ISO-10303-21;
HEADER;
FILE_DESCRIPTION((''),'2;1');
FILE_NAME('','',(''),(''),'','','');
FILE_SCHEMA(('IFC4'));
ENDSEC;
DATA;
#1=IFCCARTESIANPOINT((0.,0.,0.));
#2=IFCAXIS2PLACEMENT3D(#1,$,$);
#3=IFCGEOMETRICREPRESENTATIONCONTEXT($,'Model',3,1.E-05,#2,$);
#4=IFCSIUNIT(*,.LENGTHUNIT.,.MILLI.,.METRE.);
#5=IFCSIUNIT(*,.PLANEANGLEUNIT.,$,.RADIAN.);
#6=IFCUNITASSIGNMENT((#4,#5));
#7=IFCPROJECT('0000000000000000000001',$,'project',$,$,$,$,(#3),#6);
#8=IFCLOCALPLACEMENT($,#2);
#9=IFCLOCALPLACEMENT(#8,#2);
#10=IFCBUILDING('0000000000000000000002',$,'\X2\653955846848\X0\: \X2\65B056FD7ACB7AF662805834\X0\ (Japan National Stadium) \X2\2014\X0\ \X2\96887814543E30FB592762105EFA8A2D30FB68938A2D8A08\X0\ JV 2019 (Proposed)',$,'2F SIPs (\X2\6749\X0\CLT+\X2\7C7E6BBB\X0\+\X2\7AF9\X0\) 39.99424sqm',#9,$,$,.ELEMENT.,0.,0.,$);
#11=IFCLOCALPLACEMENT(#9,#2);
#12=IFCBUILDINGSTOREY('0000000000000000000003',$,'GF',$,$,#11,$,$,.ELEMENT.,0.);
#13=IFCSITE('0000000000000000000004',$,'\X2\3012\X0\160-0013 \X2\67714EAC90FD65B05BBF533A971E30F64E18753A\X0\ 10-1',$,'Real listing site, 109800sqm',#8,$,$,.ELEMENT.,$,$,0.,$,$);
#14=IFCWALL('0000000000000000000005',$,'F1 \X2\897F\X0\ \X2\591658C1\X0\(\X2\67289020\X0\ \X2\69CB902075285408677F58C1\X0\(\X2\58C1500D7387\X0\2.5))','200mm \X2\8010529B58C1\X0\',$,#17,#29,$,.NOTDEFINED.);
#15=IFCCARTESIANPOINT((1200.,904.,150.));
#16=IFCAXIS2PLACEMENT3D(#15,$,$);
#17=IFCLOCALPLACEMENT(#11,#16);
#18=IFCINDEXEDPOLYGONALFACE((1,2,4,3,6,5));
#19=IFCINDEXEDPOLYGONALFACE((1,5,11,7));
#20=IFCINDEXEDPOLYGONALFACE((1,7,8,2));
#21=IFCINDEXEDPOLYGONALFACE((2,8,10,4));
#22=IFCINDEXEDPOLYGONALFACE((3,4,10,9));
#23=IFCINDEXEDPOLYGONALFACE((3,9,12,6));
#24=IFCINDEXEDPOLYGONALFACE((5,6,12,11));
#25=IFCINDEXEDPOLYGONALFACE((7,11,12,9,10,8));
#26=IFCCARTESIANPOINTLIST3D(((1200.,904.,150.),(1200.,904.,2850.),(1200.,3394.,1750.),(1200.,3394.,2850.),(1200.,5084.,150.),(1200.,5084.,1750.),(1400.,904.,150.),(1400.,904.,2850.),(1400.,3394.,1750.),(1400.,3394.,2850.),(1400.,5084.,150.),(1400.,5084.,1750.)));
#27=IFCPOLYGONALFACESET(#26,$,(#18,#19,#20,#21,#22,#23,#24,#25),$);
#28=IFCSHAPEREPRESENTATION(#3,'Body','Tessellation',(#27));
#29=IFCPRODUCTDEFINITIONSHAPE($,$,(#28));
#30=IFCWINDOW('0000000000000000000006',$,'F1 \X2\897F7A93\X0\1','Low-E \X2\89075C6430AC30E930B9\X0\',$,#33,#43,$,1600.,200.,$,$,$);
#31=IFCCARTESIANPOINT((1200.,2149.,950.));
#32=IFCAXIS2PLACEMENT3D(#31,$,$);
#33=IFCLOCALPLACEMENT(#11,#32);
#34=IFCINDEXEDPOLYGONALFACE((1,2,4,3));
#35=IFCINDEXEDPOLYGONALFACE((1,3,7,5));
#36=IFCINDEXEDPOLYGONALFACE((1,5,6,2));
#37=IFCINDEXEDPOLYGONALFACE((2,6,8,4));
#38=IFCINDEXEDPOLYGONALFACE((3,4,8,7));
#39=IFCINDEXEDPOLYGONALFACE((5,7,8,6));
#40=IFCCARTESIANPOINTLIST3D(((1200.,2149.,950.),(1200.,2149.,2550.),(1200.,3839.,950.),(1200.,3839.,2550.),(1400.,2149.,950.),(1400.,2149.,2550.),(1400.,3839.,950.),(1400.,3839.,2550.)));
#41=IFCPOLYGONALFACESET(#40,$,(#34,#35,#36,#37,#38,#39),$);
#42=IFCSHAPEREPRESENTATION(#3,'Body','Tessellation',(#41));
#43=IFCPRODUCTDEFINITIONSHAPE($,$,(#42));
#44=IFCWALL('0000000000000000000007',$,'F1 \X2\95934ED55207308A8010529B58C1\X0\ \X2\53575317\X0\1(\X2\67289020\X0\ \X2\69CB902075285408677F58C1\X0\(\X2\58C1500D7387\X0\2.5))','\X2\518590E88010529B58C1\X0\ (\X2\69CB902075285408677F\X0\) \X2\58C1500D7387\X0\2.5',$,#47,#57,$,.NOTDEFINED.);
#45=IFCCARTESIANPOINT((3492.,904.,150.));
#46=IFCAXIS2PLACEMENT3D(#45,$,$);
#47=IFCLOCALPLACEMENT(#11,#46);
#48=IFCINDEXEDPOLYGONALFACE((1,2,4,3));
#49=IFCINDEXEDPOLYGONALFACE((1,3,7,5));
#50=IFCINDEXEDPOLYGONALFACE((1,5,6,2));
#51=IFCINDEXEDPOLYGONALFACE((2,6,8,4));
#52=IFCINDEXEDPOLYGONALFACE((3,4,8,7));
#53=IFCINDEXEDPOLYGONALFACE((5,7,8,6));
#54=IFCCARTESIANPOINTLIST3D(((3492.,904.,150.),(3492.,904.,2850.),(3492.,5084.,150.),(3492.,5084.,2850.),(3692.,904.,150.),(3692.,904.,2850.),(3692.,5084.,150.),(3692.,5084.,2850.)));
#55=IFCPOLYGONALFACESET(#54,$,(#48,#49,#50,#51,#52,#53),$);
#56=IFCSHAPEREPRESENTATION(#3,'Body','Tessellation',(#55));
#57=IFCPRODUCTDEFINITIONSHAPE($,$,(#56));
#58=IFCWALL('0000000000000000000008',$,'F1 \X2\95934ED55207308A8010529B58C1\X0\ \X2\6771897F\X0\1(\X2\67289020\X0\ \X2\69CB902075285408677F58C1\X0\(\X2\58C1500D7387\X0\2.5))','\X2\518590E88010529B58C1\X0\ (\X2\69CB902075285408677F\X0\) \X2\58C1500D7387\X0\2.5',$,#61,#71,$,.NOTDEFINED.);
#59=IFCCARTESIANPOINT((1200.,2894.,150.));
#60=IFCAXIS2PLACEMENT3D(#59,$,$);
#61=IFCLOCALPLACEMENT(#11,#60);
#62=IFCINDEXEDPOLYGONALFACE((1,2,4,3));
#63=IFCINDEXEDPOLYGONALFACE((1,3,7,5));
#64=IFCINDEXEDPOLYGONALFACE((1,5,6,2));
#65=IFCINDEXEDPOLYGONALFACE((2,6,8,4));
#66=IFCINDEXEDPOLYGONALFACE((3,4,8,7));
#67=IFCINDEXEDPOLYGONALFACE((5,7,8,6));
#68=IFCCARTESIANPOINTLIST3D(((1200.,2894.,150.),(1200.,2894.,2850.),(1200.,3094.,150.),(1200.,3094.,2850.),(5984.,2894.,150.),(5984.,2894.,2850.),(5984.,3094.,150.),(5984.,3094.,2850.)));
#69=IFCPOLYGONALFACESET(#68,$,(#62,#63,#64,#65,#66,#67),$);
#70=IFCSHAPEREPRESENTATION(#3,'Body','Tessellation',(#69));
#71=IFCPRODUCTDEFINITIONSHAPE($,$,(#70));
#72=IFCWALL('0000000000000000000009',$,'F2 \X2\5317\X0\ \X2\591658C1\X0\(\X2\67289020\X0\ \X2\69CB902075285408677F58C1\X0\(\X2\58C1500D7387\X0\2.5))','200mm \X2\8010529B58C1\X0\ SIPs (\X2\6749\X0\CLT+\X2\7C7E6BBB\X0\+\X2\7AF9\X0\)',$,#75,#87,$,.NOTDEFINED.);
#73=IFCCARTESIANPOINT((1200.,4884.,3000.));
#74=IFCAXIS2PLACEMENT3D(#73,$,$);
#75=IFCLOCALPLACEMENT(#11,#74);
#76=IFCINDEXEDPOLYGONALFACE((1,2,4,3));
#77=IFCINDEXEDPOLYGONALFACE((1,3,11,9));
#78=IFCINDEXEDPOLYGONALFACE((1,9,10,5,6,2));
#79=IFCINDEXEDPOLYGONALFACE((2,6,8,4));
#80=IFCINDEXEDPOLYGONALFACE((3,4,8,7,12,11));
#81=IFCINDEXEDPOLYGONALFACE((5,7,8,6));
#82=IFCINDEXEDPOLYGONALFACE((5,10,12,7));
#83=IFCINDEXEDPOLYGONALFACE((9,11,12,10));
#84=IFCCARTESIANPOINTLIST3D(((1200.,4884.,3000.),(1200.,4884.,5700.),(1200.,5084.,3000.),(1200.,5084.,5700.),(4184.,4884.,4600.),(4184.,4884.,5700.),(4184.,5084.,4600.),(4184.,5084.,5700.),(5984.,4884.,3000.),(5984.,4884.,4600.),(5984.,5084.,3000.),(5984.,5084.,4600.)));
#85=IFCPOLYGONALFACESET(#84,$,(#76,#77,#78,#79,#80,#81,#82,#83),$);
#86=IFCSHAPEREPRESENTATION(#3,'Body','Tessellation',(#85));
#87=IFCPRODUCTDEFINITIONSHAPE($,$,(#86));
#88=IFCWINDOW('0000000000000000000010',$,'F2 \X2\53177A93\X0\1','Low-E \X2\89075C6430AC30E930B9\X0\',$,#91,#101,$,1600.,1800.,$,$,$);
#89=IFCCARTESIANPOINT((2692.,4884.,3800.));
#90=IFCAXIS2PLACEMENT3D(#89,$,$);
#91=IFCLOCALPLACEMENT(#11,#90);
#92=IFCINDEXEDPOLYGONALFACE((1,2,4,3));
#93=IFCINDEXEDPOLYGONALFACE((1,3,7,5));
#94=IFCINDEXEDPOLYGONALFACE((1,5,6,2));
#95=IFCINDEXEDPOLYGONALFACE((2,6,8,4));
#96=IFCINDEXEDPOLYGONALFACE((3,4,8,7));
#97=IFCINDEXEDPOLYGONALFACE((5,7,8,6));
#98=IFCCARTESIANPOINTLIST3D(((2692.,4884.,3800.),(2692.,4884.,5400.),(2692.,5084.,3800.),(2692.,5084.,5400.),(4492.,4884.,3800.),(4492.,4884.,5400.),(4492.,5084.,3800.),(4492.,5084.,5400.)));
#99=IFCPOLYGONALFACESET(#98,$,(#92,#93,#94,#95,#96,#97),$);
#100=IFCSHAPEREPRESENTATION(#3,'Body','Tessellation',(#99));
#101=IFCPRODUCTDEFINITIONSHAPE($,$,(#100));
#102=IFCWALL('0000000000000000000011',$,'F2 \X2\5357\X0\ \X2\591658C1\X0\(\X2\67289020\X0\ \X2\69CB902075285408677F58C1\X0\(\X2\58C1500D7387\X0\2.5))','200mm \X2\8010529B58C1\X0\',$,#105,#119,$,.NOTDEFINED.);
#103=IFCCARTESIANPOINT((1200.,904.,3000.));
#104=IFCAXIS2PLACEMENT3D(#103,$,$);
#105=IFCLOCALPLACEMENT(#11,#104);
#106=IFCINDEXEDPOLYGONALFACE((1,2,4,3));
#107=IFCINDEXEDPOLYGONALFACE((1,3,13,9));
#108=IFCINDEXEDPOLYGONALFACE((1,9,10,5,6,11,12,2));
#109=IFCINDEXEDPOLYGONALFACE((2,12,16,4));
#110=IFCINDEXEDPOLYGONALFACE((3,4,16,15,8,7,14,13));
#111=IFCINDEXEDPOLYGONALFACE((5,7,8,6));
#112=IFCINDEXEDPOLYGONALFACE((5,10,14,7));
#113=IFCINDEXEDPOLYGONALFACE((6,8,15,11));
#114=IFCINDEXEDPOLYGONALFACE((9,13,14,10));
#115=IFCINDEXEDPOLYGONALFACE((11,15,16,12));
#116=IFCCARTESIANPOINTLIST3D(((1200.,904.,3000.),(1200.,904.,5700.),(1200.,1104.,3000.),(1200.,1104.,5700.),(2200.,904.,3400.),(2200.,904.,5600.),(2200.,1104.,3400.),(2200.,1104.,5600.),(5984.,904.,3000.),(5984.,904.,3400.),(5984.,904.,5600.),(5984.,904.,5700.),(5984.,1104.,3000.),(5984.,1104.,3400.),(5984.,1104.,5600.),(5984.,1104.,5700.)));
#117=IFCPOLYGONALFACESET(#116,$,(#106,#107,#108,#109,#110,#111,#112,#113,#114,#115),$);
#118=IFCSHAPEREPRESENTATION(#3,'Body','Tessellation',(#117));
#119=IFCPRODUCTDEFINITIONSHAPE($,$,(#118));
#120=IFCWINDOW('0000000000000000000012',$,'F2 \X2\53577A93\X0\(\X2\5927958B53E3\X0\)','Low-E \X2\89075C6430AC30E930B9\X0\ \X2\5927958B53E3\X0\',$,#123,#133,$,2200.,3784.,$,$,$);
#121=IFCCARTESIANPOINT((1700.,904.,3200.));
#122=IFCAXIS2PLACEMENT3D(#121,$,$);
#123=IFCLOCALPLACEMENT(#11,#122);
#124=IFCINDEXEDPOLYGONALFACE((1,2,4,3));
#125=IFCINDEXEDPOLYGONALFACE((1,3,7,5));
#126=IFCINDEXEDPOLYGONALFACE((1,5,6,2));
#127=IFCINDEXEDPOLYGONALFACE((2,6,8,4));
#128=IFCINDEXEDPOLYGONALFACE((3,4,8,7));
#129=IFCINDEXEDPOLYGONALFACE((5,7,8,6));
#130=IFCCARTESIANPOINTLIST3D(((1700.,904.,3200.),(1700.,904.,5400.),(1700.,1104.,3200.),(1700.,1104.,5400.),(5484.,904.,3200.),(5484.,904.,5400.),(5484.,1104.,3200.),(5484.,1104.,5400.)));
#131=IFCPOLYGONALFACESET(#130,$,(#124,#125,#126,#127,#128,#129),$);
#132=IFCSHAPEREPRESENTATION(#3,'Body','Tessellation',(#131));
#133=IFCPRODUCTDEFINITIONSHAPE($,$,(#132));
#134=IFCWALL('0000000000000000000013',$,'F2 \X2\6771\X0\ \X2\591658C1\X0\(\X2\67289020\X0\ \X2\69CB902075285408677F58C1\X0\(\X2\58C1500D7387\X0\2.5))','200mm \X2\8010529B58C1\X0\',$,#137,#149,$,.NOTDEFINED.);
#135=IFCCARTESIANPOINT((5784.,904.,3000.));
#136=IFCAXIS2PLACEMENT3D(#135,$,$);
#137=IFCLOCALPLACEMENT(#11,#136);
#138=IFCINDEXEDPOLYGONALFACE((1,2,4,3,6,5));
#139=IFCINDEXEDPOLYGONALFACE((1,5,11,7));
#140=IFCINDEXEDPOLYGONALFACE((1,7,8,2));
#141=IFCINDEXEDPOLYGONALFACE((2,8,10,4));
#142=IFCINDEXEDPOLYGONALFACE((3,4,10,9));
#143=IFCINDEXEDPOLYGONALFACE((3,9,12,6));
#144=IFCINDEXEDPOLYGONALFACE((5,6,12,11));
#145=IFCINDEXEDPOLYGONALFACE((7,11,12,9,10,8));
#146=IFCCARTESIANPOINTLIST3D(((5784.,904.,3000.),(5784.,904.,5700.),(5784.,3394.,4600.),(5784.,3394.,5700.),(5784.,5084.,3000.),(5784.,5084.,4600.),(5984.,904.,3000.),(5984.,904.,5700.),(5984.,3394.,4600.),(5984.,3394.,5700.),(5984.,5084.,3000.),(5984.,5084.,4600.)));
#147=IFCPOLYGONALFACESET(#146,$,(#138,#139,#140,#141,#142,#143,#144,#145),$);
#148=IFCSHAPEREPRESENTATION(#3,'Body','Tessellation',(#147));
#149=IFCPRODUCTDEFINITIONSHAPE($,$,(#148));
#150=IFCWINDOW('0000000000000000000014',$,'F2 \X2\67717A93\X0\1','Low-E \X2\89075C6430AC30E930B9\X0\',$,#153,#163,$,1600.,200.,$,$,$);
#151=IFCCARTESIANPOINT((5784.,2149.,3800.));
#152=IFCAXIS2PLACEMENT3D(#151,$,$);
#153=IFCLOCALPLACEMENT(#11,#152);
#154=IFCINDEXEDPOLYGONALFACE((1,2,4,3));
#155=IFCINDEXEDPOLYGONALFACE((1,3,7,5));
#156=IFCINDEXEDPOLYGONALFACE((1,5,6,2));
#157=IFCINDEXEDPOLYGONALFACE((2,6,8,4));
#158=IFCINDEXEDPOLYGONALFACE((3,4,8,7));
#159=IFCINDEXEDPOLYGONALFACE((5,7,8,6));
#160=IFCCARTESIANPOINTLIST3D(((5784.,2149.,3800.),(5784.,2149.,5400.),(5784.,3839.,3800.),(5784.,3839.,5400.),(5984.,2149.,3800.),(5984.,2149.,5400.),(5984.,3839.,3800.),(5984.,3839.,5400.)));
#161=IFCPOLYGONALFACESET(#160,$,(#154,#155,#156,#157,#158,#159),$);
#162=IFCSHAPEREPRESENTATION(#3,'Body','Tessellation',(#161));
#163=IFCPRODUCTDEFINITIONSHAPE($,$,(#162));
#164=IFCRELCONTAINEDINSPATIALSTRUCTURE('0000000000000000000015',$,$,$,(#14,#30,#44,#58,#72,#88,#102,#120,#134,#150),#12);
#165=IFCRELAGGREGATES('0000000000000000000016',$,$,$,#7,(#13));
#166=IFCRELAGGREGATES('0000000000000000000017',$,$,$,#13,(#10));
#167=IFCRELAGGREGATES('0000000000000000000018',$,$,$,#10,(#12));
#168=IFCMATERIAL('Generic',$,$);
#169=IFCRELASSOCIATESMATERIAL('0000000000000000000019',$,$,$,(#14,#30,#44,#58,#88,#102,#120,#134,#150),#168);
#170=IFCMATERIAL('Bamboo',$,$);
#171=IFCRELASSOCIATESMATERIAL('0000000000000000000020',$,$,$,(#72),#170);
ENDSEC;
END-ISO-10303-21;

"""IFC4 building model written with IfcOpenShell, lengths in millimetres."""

from ifc_helpers import new_model, si_unit, frame, frame_2d, origin, place, context, project, spatial, rectangle, extrude, material, element, fill, save


model = new_model("IFC4")

# Units and contexts
model_context = context("Model", 3, precision=1e-05, world=origin())
ifc_project = project(units=[si_unit("LENGTHUNIT", "METRE", prefix="MILLI"), si_unit("PLANEANGLEUNIT", "RADIAN")], contexts=[model_context])

# Site, building, storey
site_placement = place(None, origin())
site = spatial("IfcSite", under=ifc_project, at=site_placement, Name="〒160-0013 東京都新宿区霞ヶ丘町 10-1", ObjectType="Real listing site, 109800sqm", CompositionType="ELEMENT", RefElevation=0.0)
building_placement = place(site_placement, origin())
building = spatial("IfcBuilding", under=site, at=building_placement, Name="改善案: 新国立競技場 (Japan National Stadium) — 隈研吾・大成建設・梓設計 JV 2019 (Proposed)", ObjectType="2F SIPs (杉CLT+籾殻+竹) 39.99424sqm", CompositionType="ELEMENT", ElevationOfRefHeight=0.0, ElevationOfTerrain=0.0)
storey_placement = place(building_placement, origin())
storey = spatial("IfcBuildingStorey", under=building, at=storey_placement, Name="GF", CompositionType="ELEMENT", Elevation=0.0)

# Shared definitions
ifc_material_1 = material(Name="Generic")

# Shared definitions
ifc_material_2 = material(Name="Bamboo")

# Wall, opening, window
wall_1_placement = place(storey_placement, frame((1200.0, 904.0, 150.0)))
wall_1 = element("IfcWall", 1, at=wall_1_placement, inside=storey, material=ifc_material_1, Name="F1 西 外壁(木造 構造用合板壁(壁倍率2.5))", Description="200mm 耐力壁", PredefinedType="NOTDEFINED", context=model_context, shape_type="SweptSolid", body=[
    extrude(rectangle(XDim=200.0, YDim=4180.0, at=frame_2d((100.0, 2090.0))), frame((1200.0, 904.0, 150.0)), (0.0, 0.0, 1.0), 2700.0),
])
opening_1_placement = place(storey_placement, frame((1200.0, 2149.0, 950.0)))
opening_1 = element("IfcOpeningElement", 2, at=opening_1_placement, cuts=wall_1, PredefinedType="NOTDEFINED", context=model_context, shape_type="SweptSolid", body=[
    extrude(rectangle(XDim=200.0, YDim=1690.0, at=frame_2d((100.0, 845.0))), frame((1200.0, 2149.0, 950.0)), (0.0, 0.0, 1.0), 1600.0),
])
window_1_placement = place(storey_placement, frame((1200.0, 2149.0, 950.0)))
window_1 = element("IfcWindow", 3, at=window_1_placement, inside=storey, material=ifc_material_1, Name="F1 西窓1", Description="Low-E 複層ガラス", OverallHeight=1600.0, OverallWidth=200.0, context=model_context, shape_type="SweptSolid", body=[
    extrude(rectangle(XDim=200.0, YDim=1690.0, at=frame_2d((100.0, 845.0))), frame((1200.0, 2149.0, 950.0)), (0.0, 0.0, 1.0), 1600.0),
])
fill(opening_1, window_1)

# Walls
wall_2_placement = place(storey_placement, frame((3492.0, 904.0, 150.0)))
element("IfcWall", 4, at=wall_2_placement, inside=storey, material=ifc_material_1, Name="F1 間仕切り耐力壁 南北1(木造 構造用合板壁(壁倍率2.5))", Description="内部耐力壁 (構造用合板) 壁倍率2.5", PredefinedType="NOTDEFINED", context=model_context, shape_type="SweptSolid", body=[
    extrude(rectangle(XDim=200.0, YDim=4180.0, at=frame_2d((100.0, 2090.0))), frame((3492.0, 904.0, 150.0)), (0.0, 0.0, 1.0), 2700.0),
])
wall_3_placement = place(storey_placement, frame((1200.0, 2894.0, 150.0)))
element("IfcWall", 5, at=wall_3_placement, inside=storey, material=ifc_material_1, Name="F1 間仕切り耐力壁 東西1(木造 構造用合板壁(壁倍率2.5))", Description="内部耐力壁 (構造用合板) 壁倍率2.5", PredefinedType="NOTDEFINED", context=model_context, shape_type="SweptSolid", body=[
    extrude(rectangle(XDim=4784.0, YDim=200.0, at=frame_2d((2392.0, 100.0))), frame((1200.0, 2894.0, 150.0)), (0.0, 0.0, 1.0), 2700.0),
])

# Walls, openings, windows
wall_4_placement = place(storey_placement, frame((1200.0, 4884.0, 3000.0)))
wall_4 = element("IfcWall", 6, at=wall_4_placement, inside=storey, material=ifc_material_2, Name="F2 北 外壁(木造 構造用合板壁(壁倍率2.5))", Description="200mm 耐力壁 SIPs (杉CLT+籾殻+竹)", PredefinedType="NOTDEFINED", context=model_context, shape_type="SweptSolid", body=[
    extrude(rectangle(XDim=4784.0, YDim=200.0, at=frame_2d((2392.0, 100.0))), frame((1200.0, 4884.0, 3000.0)), (0.0, 0.0, 1.0), 2700.0),
])
opening_2_placement = place(storey_placement, frame((2692.0, 4884.0, 3800.0)))
opening_2 = element("IfcOpeningElement", 7, at=opening_2_placement, cuts=wall_4, PredefinedType="NOTDEFINED", context=model_context, shape_type="SweptSolid", body=[
    extrude(rectangle(XDim=1800.0, YDim=200.0, at=frame_2d((900.0, 100.0))), frame((2692.0, 4884.0, 3800.0)), (0.0, 0.0, 1.0), 1600.0),
])
window_2_placement = place(storey_placement, frame((2692.0, 4884.0, 3800.0)))
window_2 = element("IfcWindow", 8, at=window_2_placement, inside=storey, material=ifc_material_1, Name="F2 北窓1", Description="Low-E 複層ガラス", OverallHeight=1600.0, OverallWidth=1800.0, context=model_context, shape_type="SweptSolid", body=[
    extrude(rectangle(XDim=1800.0, YDim=200.0, at=frame_2d((900.0, 100.0))), frame((2692.0, 4884.0, 3800.0)), (0.0, 0.0, 1.0), 1600.0),
])
fill(opening_2, window_2)
wall_5_placement = place(storey_placement, frame((1200.0, 904.0, 3000.0)))
wall_5 = element("IfcWall", 9, at=wall_5_placement, inside=storey, material=ifc_material_1, Name="F2 南 外壁(木造 構造用合板壁(壁倍率2.5))", Description="200mm 耐力壁", PredefinedType="NOTDEFINED", context=model_context, shape_type="SweptSolid", body=[
    extrude(rectangle(XDim=4784.0, YDim=200.0, at=frame_2d((2392.0, 100.0))), frame((1200.0, 904.0, 3000.0)), (0.0, 0.0, 1.0), 2700.0),
])
opening_3_placement = place(storey_placement, frame((1700.0, 904.0, 3200.0)))
opening_3 = element("IfcOpeningElement", 10, at=opening_3_placement, cuts=wall_5, PredefinedType="NOTDEFINED", context=model_context, shape_type="SweptSolid", body=[
    extrude(rectangle(XDim=3784.0, YDim=200.0, at=frame_2d((1892.0, 100.0))), frame((1700.0, 904.0, 3200.0)), (0.0, 0.0, 1.0), 2200.0),
])
window_3_placement = place(storey_placement, frame((1700.0, 904.0, 3200.0)))
window_3 = element("IfcWindow", 11, at=window_3_placement, inside=storey, material=ifc_material_1, Name="F2 南窓(大開口)", Description="Low-E 複層ガラス 大開口", OverallHeight=2200.0, OverallWidth=3784.0, context=model_context, shape_type="SweptSolid", body=[
    extrude(rectangle(XDim=3784.0, YDim=200.0, at=frame_2d((1892.0, 100.0))), frame((1700.0, 904.0, 3200.0)), (0.0, 0.0, 1.0), 2200.0),
])
fill(opening_3, window_3)
wall_6_placement = place(storey_placement, frame((5784.0, 904.0, 3000.0)))
wall_6 = element("IfcWall", 12, at=wall_6_placement, inside=storey, material=ifc_material_1, Name="F2 東 外壁(木造 構造用合板壁(壁倍率2.5))", Description="200mm 耐力壁", PredefinedType="NOTDEFINED", context=model_context, shape_type="SweptSolid", body=[
    extrude(rectangle(XDim=200.0, YDim=4180.0, at=frame_2d((100.0, 2090.0))), frame((5784.0, 904.0, 3000.0)), (0.0, 0.0, 1.0), 2700.0),
])
opening_4_placement = place(storey_placement, frame((5784.0, 2149.0, 3800.0)))
opening_4 = element("IfcOpeningElement", 13, at=opening_4_placement, cuts=wall_6, PredefinedType="NOTDEFINED", context=model_context, shape_type="SweptSolid", body=[
    extrude(rectangle(XDim=200.0, YDim=1690.0, at=frame_2d((100.0, 845.0))), frame((5784.0, 2149.0, 3800.0)), (0.0, 0.0, 1.0), 1600.0),
])
window_4_placement = place(storey_placement, frame((5784.0, 2149.0, 3800.0)))
window_4 = element("IfcWindow", 14, at=window_4_placement, inside=storey, material=ifc_material_1, Name="F2 東窓1", Description="Low-E 複層ガラス", OverallHeight=1600.0, OverallWidth=200.0, context=model_context, shape_type="SweptSolid", body=[
    extrude(rectangle(XDim=200.0, YDim=1690.0, at=frame_2d((100.0, 845.0))), frame((5784.0, 2149.0, 3800.0)), (0.0, 0.0, 1.0), 1600.0),
])
fill(opening_4, window_4)

save(model, "model.ifc")
